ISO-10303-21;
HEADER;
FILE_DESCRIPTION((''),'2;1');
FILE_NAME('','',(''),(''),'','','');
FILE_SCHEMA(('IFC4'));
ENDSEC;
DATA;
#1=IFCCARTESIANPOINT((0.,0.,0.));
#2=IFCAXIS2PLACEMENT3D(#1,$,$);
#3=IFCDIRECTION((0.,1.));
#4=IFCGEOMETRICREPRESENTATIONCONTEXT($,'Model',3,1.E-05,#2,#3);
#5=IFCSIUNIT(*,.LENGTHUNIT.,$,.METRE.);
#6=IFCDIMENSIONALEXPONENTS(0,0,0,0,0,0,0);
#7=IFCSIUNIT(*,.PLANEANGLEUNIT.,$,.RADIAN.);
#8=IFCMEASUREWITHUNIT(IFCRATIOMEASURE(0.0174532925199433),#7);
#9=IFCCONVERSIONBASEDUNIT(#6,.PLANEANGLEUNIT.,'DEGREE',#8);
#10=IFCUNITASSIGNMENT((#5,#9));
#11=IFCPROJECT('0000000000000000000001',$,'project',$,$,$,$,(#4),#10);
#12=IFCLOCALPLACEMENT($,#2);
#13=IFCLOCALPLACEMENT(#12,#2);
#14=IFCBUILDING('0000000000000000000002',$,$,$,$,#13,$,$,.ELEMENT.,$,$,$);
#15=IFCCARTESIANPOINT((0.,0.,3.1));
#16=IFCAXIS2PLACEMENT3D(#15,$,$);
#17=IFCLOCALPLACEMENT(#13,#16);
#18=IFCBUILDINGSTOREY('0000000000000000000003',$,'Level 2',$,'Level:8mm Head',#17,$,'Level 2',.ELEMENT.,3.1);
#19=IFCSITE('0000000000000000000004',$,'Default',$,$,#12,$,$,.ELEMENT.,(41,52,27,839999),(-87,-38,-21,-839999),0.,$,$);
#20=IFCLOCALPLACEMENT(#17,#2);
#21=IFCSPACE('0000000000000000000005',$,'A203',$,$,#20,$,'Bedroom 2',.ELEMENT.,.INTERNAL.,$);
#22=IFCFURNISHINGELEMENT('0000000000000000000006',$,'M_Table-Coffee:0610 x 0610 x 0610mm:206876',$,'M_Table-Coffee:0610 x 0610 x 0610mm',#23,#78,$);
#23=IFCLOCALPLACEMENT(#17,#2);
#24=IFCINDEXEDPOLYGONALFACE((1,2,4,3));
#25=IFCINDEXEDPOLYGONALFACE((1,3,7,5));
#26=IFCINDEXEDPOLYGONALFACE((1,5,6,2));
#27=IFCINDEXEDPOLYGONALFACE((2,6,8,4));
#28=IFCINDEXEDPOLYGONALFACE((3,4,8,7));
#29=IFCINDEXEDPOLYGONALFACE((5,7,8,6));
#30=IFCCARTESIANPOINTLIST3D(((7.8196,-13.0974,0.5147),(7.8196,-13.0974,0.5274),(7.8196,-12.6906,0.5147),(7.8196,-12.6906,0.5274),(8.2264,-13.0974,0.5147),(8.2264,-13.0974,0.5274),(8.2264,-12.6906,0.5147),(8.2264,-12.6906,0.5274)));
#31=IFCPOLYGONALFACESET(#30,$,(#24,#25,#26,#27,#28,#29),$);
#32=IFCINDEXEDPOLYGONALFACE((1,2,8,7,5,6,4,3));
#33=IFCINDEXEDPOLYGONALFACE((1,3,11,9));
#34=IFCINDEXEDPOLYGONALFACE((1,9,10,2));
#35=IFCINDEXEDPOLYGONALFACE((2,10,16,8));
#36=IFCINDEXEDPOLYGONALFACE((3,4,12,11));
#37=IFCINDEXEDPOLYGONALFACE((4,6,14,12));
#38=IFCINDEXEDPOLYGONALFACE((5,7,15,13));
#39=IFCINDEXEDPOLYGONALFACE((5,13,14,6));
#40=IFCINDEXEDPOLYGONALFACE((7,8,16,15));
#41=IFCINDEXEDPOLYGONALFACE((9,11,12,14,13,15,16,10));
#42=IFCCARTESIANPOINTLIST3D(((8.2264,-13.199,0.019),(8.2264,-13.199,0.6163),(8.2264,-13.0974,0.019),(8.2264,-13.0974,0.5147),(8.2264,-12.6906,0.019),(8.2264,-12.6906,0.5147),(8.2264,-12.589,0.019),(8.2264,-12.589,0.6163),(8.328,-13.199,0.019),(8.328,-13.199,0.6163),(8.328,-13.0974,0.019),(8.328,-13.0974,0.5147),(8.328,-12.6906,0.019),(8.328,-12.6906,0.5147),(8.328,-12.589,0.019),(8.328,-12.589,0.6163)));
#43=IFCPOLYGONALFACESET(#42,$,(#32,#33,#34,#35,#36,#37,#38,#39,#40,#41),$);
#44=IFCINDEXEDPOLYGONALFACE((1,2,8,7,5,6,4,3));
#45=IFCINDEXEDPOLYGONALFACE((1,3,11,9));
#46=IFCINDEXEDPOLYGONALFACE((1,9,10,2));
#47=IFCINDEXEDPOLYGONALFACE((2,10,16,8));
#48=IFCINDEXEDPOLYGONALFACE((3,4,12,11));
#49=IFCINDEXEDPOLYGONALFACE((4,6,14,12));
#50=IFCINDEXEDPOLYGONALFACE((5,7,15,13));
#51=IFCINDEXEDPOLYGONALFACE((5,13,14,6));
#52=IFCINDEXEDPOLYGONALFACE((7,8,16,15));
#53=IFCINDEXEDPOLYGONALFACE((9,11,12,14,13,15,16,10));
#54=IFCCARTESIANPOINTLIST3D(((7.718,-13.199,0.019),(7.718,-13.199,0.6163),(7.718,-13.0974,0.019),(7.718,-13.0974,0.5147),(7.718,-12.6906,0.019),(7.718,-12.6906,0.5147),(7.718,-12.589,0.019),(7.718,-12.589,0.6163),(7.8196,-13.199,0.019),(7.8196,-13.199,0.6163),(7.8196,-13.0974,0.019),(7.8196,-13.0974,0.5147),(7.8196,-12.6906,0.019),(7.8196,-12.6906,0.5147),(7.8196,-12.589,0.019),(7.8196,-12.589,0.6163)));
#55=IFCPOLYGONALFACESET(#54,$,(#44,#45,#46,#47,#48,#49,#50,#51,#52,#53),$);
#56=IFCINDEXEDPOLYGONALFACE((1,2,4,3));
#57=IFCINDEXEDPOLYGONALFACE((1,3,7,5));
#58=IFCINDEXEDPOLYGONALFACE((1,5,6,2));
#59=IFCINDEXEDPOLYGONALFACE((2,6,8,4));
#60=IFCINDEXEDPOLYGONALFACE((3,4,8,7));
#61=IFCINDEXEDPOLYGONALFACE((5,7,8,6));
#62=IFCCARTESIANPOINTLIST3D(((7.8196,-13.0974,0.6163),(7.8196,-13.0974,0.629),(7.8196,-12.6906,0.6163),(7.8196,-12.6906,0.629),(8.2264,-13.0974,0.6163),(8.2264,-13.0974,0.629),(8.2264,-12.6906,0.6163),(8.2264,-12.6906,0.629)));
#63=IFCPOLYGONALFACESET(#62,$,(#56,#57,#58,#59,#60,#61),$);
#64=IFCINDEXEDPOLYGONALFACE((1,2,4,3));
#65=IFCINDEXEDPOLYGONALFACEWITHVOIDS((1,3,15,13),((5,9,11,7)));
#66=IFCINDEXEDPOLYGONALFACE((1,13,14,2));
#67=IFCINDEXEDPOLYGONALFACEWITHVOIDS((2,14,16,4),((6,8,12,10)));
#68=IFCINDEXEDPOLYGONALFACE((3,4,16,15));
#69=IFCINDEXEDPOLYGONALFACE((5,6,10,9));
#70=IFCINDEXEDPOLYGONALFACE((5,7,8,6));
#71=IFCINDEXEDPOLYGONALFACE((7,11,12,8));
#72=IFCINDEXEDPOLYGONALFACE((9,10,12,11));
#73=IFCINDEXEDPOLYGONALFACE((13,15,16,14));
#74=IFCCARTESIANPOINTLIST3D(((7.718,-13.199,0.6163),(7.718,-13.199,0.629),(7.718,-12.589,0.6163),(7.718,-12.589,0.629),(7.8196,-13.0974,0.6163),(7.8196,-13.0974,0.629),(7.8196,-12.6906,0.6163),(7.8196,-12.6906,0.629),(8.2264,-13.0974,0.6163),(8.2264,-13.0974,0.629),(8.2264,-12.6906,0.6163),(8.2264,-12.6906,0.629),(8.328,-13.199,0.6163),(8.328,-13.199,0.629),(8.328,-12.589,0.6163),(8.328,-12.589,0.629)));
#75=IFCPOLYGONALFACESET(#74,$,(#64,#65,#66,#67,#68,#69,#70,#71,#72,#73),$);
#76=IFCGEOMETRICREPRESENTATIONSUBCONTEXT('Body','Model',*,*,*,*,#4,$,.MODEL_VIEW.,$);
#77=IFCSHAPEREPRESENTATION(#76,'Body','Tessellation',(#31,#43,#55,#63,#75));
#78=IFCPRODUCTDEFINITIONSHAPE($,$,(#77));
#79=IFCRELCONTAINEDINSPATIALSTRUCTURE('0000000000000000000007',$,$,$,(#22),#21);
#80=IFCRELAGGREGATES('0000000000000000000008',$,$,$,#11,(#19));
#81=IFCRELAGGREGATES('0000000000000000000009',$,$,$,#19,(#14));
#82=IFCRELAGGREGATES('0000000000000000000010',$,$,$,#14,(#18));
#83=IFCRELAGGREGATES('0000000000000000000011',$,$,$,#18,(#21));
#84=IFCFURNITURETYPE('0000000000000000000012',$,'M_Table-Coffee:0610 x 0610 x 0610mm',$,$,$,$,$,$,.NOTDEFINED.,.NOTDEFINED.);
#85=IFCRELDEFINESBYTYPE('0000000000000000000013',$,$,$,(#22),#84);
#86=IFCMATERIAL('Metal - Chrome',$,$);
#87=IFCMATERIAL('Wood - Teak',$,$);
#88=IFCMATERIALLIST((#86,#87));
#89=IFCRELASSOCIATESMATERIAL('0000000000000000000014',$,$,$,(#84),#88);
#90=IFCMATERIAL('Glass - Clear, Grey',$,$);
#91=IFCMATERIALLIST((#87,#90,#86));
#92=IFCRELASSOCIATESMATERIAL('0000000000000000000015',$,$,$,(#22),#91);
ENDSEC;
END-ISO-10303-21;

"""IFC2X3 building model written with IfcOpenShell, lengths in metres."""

from ifc_helpers import new_model, entity, si_unit, converted_unit, direction, frame, origin, origin_2d_with_axis, place, context, subcontext, project, spatial, polyline, rectangle, outline, extrude, source, transform, mapped, material, material_list, type_object, type_shapes, element, save


model = new_model("IFC2X3")

# Units and contexts
model_context = context("Model", 3, precision=1e-05, world=origin(), true_north=direction((0.0, 1.0)))
body_context = subcontext(model_context, "Body", "Model", "MODEL_VIEW")
ifc_project = project(units=[si_unit("LENGTHUNIT", "METRE"), converted_unit("PLANEANGLEUNIT", "DEGREE", entity("IfcRatioMeasure", 0.0174532925199433), si_unit("PLANEANGLEUNIT", "RADIAN"), dimensions=[0, 0, 0, 0, 0, 0, 0])], contexts=[model_context])

# Site, building, storey
site_placement = place(None, origin())
site = spatial("IfcSite", under=ifc_project, at=site_placement, Name="Default", CompositionType="ELEMENT", RefLatitude=(41, 52, 27, 839999), RefLongitude=(-87, -38, -21, -839999), RefElevation=0.0)
building_placement = place(site_placement, origin())
building = spatial("IfcBuilding", under=site, at=building_placement, CompositionType="ELEMENT")
storey_placement = place(building_placement, frame((0.0, 0.0, 3.1)))
storey = spatial("IfcBuildingStorey", under=building, at=storey_placement, Name="Level 2", ObjectType="Level:8mm Head", LongName="Level 2", CompositionType="ELEMENT", Elevation=3.1)

# Shared definitions
space_placement = place(storey_placement, origin())
space = spatial("IfcSpace", under=storey, at=space_placement, Name="A203", LongName="Bedroom 2", CompositionType="ELEMENT", InteriorOrExteriorSpace="INTERNAL")

# Furnishing element
ifc_material_1 = material(Name="Wood - Teak")
ifc_material_2 = material(Name="Glass - Clear, Grey")
ifc_material_3 = material(Name="Metal - Chrome")
ifc_material_list_1 = material_list([ifc_material_1, ifc_material_2, ifc_material_3])
ifc_material_list_2 = material_list([ifc_material_3, ifc_material_1])
furniture_type_1 = type_object("IfcFurnitureType", Name="M_Table-Coffee:0610 x 0610 x 0610mm", material=ifc_material_list_2)
shared_shape_1 = source(origin(), body_context, "Body", "SweptSolid", [
    extrude(rectangle(XDim=0.4068, YDim=0.4068, at=origin_2d_with_axis()), frame((0.0183, 0.0952, 0.4957), z_axis=(0.0, 0.0, 1.0), x_axis=(-1.0, 0.0, 0.0)), (0.0, 0.0, 1.0), 0.0127),
    extrude(outline(polyline([(-0.2732, -0.305), (0.324, -0.305), (0.324, 0.305), (-0.2732, 0.305), (-0.2732, 0.2034), (0.2225, 0.2034), (0.2225, -0.2034), (-0.2732, -0.2034), (-0.2732, -0.305)])), frame((0.2217, 0.0952, 0.2732), z_axis=(1.0, 0.0, 0.0), x_axis=(0.0, 0.0, 1.0)), (0.0, 0.0, 1.0), 0.1016),
    extrude(outline(polyline([(-0.305, -0.3241), (0.305, -0.3241), (0.305, 0.2733), (0.2034, 0.2733), (0.2034, -0.2224), (-0.2034, -0.2224), (-0.2034, 0.2733), (-0.305, 0.2733), (-0.305, -0.3241)])), frame((-0.2867, 0.0952, 0.2733), z_axis=(1.0, 0.0, 0.0), x_axis=(0.0, -1.0, 0.0)), (0.0, 0.0, 1.0), 0.1016),
    extrude(rectangle(XDim=0.4068, YDim=0.4068, at=origin_2d_with_axis()), frame((0.0183, 0.0952, 0.5973), z_axis=(0.0, 0.0, 1.0), x_axis=(-1.0, 0.0, 0.0)), (0.0, 0.0, 1.0), 0.0127),
    extrude(outline(polyline([(-0.305, -0.305), (0.305, -0.305), (0.305, 0.305), (-0.305, 0.305), (-0.305, -0.305)]), holes=[polyline([(-0.2034, -0.2034), (-0.2034, 0.2034), (0.2034, 0.2034), (0.2034, -0.2034), (-0.2034, -0.2034)])]), frame((0.0183, 0.0952, 0.5973), z_axis=(0.0, 0.0, 1.0), x_axis=(-1.0, 0.0, 0.0)), (0.0, 0.0, 1.0), 0.0127),
])
type_shapes(furniture_type_1, [shared_shape_1])
furnishing_1_placement = place(space_placement, frame((8.0047, -12.9892, 0.019)))
element("IfcFurnishingElement", 1, at=furnishing_1_placement, inside=space, type_object=furniture_type_1, material=ifc_material_list_1, Name="M_Table-Coffee:0610 x 0610 x 0610mm:206876", ObjectType="M_Table-Coffee:0610 x 0610 x 0610mm", context=body_context, shape_type="MappedRepresentation", body=[
    mapped(shared_shape_1, transform((0.0, 0.0, 0.0), scale=1.0)),
])

save(model, "model.ifc")
